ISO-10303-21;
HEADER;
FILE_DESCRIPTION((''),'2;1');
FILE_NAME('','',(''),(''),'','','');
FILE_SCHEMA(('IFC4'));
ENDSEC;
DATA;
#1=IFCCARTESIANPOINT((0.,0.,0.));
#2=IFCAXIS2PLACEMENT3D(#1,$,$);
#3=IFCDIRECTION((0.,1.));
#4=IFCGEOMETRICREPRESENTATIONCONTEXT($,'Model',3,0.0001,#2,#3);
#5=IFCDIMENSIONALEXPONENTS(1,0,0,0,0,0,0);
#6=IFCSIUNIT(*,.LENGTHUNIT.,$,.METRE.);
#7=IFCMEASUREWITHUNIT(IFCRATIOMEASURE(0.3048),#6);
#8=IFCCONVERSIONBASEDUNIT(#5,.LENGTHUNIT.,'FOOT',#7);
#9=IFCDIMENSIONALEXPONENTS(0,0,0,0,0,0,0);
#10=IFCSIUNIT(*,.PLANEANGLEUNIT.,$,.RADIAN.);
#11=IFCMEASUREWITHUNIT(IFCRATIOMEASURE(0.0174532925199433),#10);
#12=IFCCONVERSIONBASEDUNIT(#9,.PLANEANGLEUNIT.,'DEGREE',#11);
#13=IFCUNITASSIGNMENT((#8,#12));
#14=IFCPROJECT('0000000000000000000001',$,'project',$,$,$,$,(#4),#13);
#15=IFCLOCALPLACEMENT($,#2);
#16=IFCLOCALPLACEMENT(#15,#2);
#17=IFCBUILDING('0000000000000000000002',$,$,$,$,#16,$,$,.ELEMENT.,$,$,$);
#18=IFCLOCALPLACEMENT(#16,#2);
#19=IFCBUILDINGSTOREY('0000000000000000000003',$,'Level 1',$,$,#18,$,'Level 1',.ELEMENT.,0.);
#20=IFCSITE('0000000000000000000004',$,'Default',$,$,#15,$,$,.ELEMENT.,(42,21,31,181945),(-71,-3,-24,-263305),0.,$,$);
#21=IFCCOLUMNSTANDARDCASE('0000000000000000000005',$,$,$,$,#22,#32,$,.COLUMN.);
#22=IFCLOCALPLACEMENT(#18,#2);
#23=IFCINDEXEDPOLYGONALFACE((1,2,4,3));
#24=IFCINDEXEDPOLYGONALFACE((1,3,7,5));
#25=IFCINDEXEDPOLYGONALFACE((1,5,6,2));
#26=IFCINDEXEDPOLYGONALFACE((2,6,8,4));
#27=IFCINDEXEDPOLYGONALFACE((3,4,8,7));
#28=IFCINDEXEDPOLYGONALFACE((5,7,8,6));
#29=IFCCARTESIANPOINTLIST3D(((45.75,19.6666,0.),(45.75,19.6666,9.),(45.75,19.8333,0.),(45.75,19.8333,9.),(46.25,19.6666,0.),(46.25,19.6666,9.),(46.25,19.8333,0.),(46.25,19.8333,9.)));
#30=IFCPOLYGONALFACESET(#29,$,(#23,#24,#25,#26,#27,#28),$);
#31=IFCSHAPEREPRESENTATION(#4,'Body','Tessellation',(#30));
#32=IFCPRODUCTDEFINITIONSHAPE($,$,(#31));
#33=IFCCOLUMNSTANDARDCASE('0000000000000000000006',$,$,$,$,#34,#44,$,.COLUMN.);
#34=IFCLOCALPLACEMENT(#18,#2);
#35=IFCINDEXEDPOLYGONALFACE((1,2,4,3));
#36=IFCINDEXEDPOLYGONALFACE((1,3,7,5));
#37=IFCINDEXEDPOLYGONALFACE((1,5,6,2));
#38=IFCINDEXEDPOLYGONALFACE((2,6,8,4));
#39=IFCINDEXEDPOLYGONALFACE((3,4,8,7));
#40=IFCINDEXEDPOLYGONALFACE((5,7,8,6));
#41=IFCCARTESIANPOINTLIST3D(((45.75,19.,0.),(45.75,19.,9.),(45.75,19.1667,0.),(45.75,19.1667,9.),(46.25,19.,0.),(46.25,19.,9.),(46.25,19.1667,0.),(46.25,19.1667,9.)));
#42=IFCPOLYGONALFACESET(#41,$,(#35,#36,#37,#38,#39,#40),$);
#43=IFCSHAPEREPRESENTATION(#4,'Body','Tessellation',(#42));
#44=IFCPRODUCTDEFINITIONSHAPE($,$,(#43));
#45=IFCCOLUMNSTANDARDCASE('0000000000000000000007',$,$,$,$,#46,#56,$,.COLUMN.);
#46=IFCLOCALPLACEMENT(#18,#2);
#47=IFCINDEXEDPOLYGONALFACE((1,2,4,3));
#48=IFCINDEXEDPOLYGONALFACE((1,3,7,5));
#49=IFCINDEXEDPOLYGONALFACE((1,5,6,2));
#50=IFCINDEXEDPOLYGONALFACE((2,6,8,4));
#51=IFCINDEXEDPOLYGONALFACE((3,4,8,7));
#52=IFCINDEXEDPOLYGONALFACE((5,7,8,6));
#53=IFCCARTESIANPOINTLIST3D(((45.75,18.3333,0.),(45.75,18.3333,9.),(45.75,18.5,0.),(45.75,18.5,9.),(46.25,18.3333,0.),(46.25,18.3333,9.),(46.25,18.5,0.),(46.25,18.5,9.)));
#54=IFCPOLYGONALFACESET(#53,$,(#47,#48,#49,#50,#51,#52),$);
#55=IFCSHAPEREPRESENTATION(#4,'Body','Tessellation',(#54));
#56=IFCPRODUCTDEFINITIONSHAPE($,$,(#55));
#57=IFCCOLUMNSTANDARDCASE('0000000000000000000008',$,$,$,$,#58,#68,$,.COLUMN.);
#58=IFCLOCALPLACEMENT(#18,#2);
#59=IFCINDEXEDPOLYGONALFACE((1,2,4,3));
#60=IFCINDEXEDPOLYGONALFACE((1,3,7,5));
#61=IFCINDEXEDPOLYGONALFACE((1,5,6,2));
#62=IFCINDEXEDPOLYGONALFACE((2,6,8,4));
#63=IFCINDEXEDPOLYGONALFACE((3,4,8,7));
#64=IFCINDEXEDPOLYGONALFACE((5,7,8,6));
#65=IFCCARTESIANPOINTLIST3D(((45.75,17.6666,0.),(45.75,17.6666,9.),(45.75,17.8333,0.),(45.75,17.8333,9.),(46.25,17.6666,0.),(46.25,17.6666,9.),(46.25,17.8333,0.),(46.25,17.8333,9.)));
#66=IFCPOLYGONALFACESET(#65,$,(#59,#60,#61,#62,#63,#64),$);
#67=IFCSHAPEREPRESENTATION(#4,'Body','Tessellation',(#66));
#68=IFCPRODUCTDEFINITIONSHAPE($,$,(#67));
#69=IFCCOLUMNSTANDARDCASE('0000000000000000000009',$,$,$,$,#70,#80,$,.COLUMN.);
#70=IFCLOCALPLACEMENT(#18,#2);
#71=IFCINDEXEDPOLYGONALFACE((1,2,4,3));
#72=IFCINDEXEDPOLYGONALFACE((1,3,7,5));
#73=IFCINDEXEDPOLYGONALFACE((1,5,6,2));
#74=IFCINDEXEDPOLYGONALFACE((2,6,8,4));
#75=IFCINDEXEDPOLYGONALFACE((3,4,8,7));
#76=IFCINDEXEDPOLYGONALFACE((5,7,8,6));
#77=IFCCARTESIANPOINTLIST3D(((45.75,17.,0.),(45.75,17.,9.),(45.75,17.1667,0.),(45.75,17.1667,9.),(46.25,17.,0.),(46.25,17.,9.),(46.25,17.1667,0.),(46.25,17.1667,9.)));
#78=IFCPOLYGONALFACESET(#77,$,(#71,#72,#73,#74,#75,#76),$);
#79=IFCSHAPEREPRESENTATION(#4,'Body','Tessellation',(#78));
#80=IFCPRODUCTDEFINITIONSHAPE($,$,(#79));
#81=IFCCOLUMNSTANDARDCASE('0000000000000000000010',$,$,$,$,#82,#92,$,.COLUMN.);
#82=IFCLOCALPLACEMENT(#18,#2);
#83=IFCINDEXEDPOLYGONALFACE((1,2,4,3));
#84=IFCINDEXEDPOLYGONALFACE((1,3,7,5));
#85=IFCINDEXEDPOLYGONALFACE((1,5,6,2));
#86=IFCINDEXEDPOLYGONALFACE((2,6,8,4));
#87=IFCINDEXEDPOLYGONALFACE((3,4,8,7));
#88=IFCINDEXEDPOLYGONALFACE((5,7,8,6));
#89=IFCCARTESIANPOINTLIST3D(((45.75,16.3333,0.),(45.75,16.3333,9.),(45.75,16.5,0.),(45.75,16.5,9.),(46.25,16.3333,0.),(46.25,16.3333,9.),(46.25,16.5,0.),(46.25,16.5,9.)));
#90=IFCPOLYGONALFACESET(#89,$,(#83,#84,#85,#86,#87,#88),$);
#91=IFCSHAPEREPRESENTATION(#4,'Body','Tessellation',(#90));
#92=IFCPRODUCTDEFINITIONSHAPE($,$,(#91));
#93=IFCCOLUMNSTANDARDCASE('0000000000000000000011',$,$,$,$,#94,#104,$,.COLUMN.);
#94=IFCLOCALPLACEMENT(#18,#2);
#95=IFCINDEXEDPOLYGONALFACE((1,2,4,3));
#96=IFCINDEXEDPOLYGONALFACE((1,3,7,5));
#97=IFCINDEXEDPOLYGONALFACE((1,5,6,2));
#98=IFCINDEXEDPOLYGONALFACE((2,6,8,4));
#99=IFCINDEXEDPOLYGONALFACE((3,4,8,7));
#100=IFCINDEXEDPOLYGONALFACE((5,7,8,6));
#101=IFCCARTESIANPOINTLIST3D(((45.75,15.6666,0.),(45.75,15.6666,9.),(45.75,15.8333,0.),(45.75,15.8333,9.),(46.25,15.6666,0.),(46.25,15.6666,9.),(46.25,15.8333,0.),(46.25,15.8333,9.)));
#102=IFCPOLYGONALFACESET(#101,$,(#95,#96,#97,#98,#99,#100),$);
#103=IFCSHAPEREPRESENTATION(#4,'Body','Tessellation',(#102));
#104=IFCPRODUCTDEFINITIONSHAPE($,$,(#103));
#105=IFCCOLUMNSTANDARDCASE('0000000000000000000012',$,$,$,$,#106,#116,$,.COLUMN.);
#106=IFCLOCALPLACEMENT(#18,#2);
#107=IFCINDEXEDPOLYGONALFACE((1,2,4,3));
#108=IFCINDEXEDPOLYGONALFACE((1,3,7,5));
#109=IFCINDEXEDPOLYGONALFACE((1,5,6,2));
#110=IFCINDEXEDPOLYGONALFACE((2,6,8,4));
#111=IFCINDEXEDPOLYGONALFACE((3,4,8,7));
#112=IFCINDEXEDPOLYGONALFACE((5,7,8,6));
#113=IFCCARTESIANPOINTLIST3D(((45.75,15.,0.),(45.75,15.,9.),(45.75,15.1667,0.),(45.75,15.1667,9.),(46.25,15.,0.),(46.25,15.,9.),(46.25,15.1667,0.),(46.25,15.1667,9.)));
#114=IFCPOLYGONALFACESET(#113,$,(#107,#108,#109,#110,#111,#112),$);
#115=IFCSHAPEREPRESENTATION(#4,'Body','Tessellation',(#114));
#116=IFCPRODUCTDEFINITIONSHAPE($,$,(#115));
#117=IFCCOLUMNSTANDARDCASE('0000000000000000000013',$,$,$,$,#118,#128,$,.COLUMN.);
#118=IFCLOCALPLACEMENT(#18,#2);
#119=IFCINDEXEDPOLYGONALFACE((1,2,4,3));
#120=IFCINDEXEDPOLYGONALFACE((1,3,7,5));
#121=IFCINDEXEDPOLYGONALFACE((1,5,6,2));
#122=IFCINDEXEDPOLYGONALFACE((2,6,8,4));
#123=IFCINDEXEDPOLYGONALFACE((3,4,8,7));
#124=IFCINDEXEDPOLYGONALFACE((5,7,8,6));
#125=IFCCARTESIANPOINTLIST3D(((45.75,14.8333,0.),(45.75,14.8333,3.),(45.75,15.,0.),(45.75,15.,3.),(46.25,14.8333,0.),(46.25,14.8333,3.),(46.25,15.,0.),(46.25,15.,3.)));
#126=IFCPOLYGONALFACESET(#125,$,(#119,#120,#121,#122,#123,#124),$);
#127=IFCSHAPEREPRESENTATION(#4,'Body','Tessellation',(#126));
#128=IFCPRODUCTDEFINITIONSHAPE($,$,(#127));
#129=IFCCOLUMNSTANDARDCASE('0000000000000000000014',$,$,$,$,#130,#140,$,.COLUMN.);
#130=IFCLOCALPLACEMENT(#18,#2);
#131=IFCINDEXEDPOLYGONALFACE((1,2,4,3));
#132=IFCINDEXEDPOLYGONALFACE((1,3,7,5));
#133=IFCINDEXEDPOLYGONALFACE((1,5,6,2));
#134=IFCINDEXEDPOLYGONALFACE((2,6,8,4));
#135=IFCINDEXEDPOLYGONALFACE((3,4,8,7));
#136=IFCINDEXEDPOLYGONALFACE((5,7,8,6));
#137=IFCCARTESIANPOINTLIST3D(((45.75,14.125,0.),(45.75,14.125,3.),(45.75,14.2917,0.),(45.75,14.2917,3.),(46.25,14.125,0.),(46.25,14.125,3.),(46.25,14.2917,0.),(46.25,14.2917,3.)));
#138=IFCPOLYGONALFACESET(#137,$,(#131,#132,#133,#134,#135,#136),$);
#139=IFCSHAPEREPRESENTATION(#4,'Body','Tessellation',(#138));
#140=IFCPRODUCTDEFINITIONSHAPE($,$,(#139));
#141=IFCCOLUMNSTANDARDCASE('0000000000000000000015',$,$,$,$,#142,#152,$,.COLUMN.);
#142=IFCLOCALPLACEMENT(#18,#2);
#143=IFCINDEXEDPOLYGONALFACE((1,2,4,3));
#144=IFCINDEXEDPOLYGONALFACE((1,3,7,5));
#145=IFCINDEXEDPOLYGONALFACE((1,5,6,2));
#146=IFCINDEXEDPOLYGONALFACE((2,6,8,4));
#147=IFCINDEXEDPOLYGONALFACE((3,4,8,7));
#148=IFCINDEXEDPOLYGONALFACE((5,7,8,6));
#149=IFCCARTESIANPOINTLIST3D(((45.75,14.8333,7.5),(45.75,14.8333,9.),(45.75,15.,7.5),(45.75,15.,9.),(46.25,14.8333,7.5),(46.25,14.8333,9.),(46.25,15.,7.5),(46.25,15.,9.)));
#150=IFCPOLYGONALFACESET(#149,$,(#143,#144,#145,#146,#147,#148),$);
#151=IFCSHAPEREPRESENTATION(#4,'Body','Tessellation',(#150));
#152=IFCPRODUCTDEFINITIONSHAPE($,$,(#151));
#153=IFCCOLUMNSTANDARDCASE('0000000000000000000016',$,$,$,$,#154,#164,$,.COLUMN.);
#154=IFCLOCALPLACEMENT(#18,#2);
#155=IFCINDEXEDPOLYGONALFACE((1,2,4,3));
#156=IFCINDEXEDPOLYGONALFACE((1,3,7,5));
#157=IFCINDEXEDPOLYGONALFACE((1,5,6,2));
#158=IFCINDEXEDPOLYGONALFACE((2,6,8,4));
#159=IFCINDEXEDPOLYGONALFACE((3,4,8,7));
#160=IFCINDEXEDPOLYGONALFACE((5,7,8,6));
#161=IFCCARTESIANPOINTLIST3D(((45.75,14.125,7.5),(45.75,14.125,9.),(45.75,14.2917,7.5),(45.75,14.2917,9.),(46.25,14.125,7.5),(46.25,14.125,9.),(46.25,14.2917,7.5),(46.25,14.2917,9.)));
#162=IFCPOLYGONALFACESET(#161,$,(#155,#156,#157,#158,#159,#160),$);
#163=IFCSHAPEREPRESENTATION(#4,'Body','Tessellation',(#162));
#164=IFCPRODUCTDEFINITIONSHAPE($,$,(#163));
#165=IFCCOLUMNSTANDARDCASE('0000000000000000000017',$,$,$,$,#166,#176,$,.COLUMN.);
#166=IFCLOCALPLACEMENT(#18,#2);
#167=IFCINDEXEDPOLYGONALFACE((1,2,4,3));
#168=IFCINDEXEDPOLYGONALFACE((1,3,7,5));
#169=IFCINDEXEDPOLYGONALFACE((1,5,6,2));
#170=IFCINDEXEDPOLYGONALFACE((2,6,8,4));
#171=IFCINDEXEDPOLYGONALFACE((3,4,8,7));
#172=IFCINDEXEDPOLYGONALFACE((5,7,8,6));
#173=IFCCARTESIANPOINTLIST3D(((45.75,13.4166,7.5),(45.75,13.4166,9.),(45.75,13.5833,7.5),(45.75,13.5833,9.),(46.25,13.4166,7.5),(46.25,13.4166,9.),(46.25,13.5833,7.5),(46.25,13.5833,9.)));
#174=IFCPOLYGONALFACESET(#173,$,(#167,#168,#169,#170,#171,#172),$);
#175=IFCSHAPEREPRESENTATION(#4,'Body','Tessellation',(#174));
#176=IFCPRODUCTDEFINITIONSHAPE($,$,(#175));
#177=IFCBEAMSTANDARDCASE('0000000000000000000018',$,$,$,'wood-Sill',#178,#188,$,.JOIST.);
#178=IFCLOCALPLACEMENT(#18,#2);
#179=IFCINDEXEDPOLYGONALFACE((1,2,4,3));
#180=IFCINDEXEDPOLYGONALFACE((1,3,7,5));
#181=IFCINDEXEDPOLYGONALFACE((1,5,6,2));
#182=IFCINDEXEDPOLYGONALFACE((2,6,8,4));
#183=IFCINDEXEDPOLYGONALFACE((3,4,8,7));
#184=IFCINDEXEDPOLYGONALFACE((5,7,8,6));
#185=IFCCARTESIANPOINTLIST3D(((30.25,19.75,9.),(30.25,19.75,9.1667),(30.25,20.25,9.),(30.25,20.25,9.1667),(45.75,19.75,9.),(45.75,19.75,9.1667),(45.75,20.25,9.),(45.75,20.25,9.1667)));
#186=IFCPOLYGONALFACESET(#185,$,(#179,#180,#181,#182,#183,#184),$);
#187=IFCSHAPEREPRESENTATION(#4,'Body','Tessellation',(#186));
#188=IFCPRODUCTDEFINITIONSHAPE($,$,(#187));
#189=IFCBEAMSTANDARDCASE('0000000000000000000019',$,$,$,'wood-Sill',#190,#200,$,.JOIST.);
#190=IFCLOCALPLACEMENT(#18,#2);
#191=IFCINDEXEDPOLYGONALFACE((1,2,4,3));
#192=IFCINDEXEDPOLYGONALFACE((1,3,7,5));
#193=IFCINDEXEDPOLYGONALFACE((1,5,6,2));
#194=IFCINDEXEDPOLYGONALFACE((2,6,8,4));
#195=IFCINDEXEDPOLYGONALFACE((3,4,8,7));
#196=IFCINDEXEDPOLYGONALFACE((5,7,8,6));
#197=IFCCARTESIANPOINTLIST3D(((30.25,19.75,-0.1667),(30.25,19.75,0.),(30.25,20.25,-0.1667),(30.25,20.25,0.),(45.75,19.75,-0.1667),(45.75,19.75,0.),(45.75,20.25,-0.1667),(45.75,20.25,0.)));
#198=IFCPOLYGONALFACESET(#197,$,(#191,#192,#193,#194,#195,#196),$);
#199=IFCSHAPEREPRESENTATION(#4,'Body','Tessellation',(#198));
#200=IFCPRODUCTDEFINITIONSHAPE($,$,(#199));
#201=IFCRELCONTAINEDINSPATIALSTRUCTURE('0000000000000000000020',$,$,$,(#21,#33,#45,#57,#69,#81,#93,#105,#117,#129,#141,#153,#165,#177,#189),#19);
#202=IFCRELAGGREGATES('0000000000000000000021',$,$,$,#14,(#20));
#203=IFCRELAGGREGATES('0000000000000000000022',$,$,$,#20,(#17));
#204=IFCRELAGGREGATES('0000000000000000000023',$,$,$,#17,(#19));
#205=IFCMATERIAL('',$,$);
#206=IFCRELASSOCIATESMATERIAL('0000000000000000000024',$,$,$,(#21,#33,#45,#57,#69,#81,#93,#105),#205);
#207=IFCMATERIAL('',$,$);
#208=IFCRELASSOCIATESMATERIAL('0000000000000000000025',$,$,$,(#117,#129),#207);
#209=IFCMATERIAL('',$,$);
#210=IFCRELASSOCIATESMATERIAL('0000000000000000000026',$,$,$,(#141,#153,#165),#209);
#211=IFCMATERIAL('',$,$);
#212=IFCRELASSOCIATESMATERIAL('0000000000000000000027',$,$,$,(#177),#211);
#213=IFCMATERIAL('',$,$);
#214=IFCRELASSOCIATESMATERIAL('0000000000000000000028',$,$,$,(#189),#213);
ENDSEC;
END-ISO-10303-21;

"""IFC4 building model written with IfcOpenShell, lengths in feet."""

from ifc_helpers import new_model, entity, si_unit, converted_unit, direction, frame, origin, place, context, project, spatial, rectangle, extrude, material, element, save


model = new_model("IFC4")

# Units and contexts
model_context = context("Model", 3, precision=0.0001, world=origin(), true_north=direction((0.0, 1.0)))
ifc_project = project(units=[converted_unit("LENGTHUNIT", "FOOT", entity("IfcRatioMeasure", 0.3048), si_unit("LENGTHUNIT", "METRE"), dimensions=[1, 0, 0, 0, 0, 0, 0]), converted_unit("PLANEANGLEUNIT", "DEGREE", entity("IfcRatioMeasure", 0.0174532925199433), si_unit("PLANEANGLEUNIT", "RADIAN"), dimensions=[0, 0, 0, 0, 0, 0, 0])], contexts=[model_context])

# Site, building, storey
site_placement = place(None, origin())
site = spatial("IfcSite", under=ifc_project, at=site_placement, Name="Default", CompositionType="ELEMENT", RefLatitude=(42, 21, 31, 181945), RefLongitude=(-71, -3, -24, -263305), RefElevation=0.0)
building_placement = place(site_placement, origin())
building = spatial("IfcBuilding", under=site, at=building_placement, CompositionType="ELEMENT")
storey_placement = place(building_placement, origin())
storey = spatial("IfcBuildingStorey", under=building, at=storey_placement, Name="Level 1", LongName="Level 1", CompositionType="ELEMENT", Elevation=0.0)

# Columns
ifc_material_1 = material(Name="")
placement_1 = place(storey_placement, frame((46.0, 46.25, 0.0), z_axis=(0.0, 0.0, 1.0), x_axis=(0.0, -1.0, 0.0)))
for number, where, z_axis, x_axis in (
    (1, (26.5001, 0.0, 0.0), (0.0, 0.0, 1.0), (1.0, 0.0, 0.0)),
    (2, (27.1667, 0.0, 0.0), (0.0, 0.0, 1.0), (1.0, 0.0, 0.0)),
    (3, (27.8334, 0.0, 0.0), (0.0, 0.0, 1.0), (1.0, 0.0, 0.0)),
    (4, (28.5001, 0.0, 0.0), (0.0, 0.0, 1.0), (1.0, 0.0, 0.0)),
    (5, (29.1667, 0.0, 0.0), (0.0, 0.0, 1.0), (1.0, 0.0, 0.0)),
    (6, (29.8334, 0.0, 0.0), (0.0, 0.0, 1.0), (1.0, 0.0, 0.0)),
    (7, (30.5001, 0.0, 0.0), (0.0, 0.0, 1.0), (1.0, 0.0, 0.0)),
    (8, (31.1667, 0.0, 0.0), (0.0, 0.0, 1.0), (1.0, 0.0, 0.0)),
):
    element("IfcColumnStandardCase", number, at=place(placement_1, frame(where, z_axis=z_axis, x_axis=x_axis)), inside=storey, material=ifc_material_1, PredefinedType="COLUMN", context=model_context, shape_type="SweptSolid", body=[
        extrude(rectangle(XDim=0.1667, YDim=0.5), origin(), (0.0, 0.0, 1.0), 9.0),
    ])
ifc_material_2 = material(Name="")
for number, where, z_axis, x_axis in (
    (9, (31.3334, 0.0, 0.0), (0.0, 0.0, 1.0), (1.0, 0.0, 0.0)),
    (10, (32.0417, 0.0, 0.0), (0.0, 0.0, 1.0), (1.0, 0.0, 0.0)),
):
    element("IfcColumnStandardCase", number, at=place(placement_1, frame(where, z_axis=z_axis, x_axis=x_axis)), inside=storey, material=ifc_material_2, PredefinedType="COLUMN", context=model_context, shape_type="SweptSolid", body=[
        extrude(rectangle(XDim=0.1667, YDim=0.5), origin(), (0.0, 0.0, 1.0), 3.0),
    ])
ifc_material_3 = material(Name="")
for number, where, z_axis, x_axis in (
    (11, (31.3334, 0.0, 7.5), (0.0, 0.0, 1.0), (1.0, 0.0, 0.0)),
    (12, (32.0417, 0.0, 7.5), (0.0, 0.0, 1.0), (1.0, 0.0, 0.0)),
    (13, (32.7501, 0.0, 7.5), (0.0, 0.0, 1.0), (1.0, 0.0, 0.0)),
):
    element("IfcColumnStandardCase", number, at=place(placement_1, frame(where, z_axis=z_axis, x_axis=x_axis)), inside=storey, material=ifc_material_3, PredefinedType="COLUMN", context=model_context, shape_type="SweptSolid", body=[
        extrude(rectangle(XDim=0.1667, YDim=0.5), origin(), (0.0, 0.0, 1.0), 1.5),
    ])
placement_2 = place(storey_placement, frame((30.25, 20.0, 0.0)))

# Beams
ifc_material_4 = material(Name="")
beam_1_placement = place(placement_2, frame((7.75, 0.0, 9.0), z_axis=(0.0, 0.0, 1.0), x_axis=(1.0, 0.0, 0.0)))
element("IfcBeamStandardCase", 14, at=beam_1_placement, inside=storey, material=ifc_material_4, ObjectType="wood-Sill", PredefinedType="JOIST", context=model_context, shape_type="SweptSolid", body=[
    extrude(rectangle(XDim=15.5, YDim=0.5), origin(), (0.0, 0.0, 1.0), 0.1667),
])
ifc_material_5 = material(Name="")
beam_2_placement = place(placement_2, frame((7.75, 0.0, -0.1667), z_axis=(0.0, 0.0, 1.0), x_axis=(1.0, 0.0, 0.0)))
element("IfcBeamStandardCase", 15, at=beam_2_placement, inside=storey, material=ifc_material_5, ObjectType="wood-Sill", PredefinedType="JOIST", context=model_context, shape_type="SweptSolid", body=[
    extrude(rectangle(XDim=15.5, YDim=0.5), origin(), (0.0, 0.0, 1.0), 0.1667),
])

save(model, "model.ifc")
